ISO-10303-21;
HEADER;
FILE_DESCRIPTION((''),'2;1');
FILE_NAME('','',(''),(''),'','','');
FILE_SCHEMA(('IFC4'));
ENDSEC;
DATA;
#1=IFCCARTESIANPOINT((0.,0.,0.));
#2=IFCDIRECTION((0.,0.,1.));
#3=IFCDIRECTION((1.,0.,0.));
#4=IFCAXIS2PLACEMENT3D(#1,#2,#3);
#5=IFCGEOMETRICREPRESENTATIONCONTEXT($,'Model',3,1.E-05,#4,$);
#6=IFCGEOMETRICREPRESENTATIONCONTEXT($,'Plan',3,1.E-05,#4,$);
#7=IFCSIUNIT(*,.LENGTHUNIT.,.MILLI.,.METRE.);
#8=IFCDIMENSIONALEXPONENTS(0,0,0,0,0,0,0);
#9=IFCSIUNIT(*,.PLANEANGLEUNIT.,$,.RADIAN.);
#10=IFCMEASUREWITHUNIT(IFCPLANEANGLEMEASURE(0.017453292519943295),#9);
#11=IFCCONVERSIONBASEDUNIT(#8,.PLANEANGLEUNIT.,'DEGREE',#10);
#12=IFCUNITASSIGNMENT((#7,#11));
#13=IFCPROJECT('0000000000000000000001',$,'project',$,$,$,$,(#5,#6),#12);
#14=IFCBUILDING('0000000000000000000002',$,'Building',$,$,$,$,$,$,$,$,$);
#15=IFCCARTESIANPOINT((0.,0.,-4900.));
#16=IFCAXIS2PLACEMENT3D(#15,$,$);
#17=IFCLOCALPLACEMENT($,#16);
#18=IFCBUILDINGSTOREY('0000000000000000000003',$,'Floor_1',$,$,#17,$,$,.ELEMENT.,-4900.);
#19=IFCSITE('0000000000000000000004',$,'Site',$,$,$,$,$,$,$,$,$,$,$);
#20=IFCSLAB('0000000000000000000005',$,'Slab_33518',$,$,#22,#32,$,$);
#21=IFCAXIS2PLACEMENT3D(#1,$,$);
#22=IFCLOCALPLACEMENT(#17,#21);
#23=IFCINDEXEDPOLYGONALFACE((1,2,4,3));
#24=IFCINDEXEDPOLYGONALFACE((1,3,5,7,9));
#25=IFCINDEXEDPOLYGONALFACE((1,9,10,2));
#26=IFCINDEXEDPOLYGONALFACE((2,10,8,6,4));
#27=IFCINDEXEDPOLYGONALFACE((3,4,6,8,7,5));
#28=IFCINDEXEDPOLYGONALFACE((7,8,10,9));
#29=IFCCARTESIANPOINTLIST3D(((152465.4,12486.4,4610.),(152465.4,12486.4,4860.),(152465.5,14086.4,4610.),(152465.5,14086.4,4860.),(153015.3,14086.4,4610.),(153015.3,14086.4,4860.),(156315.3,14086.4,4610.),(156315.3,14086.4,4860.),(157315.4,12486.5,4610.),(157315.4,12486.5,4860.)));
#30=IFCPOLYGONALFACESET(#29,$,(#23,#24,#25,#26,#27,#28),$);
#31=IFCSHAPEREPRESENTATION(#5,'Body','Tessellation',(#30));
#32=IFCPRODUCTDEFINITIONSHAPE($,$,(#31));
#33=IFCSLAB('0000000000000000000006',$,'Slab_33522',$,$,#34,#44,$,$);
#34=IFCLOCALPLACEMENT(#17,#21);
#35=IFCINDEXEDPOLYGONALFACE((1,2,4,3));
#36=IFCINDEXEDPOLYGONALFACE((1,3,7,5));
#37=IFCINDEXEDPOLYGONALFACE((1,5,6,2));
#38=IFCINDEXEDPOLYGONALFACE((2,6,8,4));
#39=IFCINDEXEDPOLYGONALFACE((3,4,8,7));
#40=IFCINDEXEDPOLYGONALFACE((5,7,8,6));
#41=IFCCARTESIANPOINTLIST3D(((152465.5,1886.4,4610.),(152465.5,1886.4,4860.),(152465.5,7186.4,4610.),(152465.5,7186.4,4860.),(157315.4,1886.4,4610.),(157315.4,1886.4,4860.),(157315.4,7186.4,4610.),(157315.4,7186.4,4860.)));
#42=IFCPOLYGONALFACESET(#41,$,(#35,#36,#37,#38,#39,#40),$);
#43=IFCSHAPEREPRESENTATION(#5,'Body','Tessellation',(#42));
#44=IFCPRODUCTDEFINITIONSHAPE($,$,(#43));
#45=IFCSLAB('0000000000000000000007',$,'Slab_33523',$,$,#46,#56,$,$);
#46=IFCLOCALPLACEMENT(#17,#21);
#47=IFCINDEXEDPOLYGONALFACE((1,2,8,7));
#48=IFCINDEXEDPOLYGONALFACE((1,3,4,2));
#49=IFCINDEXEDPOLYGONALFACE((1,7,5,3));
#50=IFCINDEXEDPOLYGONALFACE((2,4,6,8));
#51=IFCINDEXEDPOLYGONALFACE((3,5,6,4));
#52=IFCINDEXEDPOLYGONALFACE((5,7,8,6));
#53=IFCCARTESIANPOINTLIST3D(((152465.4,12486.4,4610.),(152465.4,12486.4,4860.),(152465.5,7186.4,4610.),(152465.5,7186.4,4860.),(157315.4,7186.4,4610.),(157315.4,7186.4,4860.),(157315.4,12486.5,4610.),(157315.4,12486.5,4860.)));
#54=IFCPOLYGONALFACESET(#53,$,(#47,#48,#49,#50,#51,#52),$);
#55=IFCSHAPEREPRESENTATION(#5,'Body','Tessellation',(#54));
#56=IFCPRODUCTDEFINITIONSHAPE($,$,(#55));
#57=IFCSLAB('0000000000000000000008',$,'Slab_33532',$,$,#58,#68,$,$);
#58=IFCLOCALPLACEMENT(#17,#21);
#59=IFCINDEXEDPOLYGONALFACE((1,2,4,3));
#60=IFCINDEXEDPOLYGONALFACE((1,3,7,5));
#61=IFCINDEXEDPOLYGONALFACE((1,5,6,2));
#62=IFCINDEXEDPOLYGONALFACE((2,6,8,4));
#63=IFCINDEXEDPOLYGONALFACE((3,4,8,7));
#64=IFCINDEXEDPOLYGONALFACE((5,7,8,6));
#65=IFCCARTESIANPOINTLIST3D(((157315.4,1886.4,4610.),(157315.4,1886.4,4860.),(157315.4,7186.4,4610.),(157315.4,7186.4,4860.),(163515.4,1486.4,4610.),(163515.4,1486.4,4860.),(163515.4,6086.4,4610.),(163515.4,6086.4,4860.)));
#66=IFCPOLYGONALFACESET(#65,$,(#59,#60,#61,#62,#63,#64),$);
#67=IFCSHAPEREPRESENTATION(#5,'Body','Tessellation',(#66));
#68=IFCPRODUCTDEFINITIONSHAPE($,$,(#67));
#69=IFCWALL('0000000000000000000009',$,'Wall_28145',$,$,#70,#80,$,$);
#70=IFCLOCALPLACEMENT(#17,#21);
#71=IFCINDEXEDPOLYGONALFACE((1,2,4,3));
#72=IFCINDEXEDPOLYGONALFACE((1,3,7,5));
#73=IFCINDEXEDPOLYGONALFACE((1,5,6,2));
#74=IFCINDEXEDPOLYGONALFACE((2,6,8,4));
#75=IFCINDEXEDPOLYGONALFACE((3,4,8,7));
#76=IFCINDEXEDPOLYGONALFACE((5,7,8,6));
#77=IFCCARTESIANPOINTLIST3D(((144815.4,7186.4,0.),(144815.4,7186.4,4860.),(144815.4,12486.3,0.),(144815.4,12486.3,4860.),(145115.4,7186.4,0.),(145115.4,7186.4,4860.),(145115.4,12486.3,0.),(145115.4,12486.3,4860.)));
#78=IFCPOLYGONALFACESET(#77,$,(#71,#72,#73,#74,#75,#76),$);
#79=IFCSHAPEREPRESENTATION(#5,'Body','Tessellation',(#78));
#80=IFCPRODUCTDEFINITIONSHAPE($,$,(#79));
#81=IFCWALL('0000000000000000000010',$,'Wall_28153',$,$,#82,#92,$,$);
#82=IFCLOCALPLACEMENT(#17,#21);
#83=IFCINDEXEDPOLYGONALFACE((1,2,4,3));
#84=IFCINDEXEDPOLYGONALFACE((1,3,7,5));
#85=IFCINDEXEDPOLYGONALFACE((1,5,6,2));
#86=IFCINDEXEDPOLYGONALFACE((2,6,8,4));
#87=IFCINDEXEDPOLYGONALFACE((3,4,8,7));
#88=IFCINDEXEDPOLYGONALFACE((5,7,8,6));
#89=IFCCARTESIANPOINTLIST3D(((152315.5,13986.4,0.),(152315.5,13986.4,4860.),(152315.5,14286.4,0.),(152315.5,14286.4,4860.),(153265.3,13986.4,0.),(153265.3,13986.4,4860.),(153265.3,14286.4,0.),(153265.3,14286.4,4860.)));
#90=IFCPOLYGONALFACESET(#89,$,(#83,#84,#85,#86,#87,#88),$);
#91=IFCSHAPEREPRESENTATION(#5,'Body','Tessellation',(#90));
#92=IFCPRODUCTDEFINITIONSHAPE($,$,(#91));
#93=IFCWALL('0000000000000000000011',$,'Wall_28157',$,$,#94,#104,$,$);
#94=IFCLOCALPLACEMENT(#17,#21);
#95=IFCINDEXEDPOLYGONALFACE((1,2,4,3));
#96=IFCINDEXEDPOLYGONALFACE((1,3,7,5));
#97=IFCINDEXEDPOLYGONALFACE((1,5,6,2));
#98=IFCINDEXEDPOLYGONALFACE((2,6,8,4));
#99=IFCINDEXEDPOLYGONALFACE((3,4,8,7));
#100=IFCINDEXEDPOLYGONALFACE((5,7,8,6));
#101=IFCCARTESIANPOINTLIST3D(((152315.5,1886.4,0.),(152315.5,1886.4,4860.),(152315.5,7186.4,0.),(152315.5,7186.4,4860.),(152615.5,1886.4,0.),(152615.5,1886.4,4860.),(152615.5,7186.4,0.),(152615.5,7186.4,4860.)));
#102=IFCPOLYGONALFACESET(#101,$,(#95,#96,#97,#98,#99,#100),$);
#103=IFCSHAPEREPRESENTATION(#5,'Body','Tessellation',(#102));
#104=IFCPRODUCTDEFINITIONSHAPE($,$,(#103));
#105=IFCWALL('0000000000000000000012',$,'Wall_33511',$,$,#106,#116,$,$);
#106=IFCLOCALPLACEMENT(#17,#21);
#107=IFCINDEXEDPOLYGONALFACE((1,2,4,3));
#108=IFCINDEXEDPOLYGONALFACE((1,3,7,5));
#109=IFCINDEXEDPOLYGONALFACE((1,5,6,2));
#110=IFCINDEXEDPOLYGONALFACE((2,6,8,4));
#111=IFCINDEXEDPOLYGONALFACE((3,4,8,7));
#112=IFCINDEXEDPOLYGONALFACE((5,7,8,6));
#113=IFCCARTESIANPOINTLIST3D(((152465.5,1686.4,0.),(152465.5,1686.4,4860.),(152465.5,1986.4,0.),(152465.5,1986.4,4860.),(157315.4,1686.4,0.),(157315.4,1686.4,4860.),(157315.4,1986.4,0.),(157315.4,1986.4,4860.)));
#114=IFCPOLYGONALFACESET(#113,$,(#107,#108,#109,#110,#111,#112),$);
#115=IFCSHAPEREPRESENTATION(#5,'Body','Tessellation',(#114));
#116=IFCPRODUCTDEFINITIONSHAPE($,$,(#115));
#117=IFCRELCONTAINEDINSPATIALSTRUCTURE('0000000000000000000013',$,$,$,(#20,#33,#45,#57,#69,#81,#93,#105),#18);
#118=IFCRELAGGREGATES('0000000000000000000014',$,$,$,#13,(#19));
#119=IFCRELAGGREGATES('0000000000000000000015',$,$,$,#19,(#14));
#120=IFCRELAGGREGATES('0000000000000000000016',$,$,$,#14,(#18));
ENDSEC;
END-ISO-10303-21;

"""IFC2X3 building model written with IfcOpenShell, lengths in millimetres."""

from ifc_helpers import new_model, entity, si_unit, converted_unit, frame, origin_with_axes, origin_2d, place, context, project, spatial, polyline, rectangle, outline, extrude, element, save


model = new_model("IFC2X3")

# Units and contexts
model_context = context("Model", 3, precision=1e-05, world=origin_with_axes())
plan_context = context("Plan", 3, precision=1e-05, world=origin_with_axes())
ifc_project = project(units=[si_unit("LENGTHUNIT", "METRE", prefix="MILLI"), converted_unit("PLANEANGLEUNIT", "DEGREE", entity("IfcPlaneAngleMeasure", 0.017453292519943295), si_unit("PLANEANGLEUNIT", "RADIAN"), dimensions=[0, 0, 0, 0, 0, 0, 0])], contexts=[model_context, plan_context])

# Site, building, storey
site = spatial("IfcSite", under=ifc_project, Name="Site")
building = spatial("IfcBuilding", under=site, Name="Building")
storey_placement = place(None, frame((0.0, 0.0, -4900.0)))
storey = spatial("IfcBuildingStorey", under=building, at=storey_placement, Name="Floor_1", CompositionType="ELEMENT", Elevation=-4900.0)

# Slabs
slab_1_placement = place(storey_placement, frame((153015.3, 14086.4, 4610.0), z_axis=(0.0, 0.0, 1.0), x_axis=(-549.854, 0.0, 0.0)))
element("IfcSlab", 1, at=slab_1_placement, inside=storey, Name="Slab_33518", context=model_context, shape_type="SweptSolid", body=[
    extrude(outline(polyline([(0.0, 0.0), (549.9, 0.0), (549.9, 1600.0), (-4300.1, 1599.9), (-3300.0, 0.0)])), origin_with_axes(), (0.0, 0.0, 1.0), 250.0),
])
slab_2_placement = place(storey_placement, frame((152465.5, 7186.4, 4610.0), z_axis=(0.0, 0.0, 1.0), x_axis=(0.0, -5300.0, 0.0)))
element("IfcSlab", 2, at=slab_2_placement, inside=storey, Name="Slab_33522", context=model_context, shape_type="SweptSolid", body=[
    extrude(outline(polyline([(0.0, 0.0), (5300.0, 0.0), (5300.0, 4849.9), (0.0, 4849.9)])), origin_with_axes(), (0.0, 0.0, 1.0), 250.0),
])
slab_3_placement = place(storey_placement, frame((152465.4, 12486.4, 4610.0), z_axis=(0.0, 0.0, 1.0), x_axis=(0.052, -5300.046, 0.0)))
element("IfcSlab", 3, at=slab_3_placement, inside=storey, Name="Slab_33523", context=model_context, shape_type="SweptSolid", body=[
    extrude(outline(polyline([(0.0, 0.0), (5300.0, 0.0), (5300.1, 4849.9), (0.0, 4850.0)])), origin_with_axes(), (0.0, 0.0, 1.0), 250.0),
])
slab_4_placement = place(storey_placement, frame((157315.4, 7186.4, 4610.0), z_axis=(0.0, 0.0, 1.0), x_axis=(0.0, -5300.012, 0.0)))
element("IfcSlab", 4, at=slab_4_placement, inside=storey, Name="Slab_33532", context=model_context, shape_type="SweptSolid", body=[
    extrude(outline(polyline([(0.0, 0.0), (5300.0, 0.0), (5700.0, 6200.0), (1100.0, 6200.0)])), origin_with_axes(), (0.0, 0.0, 1.0), 250.0),
])

# Walls
wall_1_placement = place(storey_placement, frame((144965.4, 9836.3, 0.0), z_axis=(0.0, 0.0, 1.0), x_axis=(0.0, 5299.937, 0.0)))
element("IfcWall", 5, at=wall_1_placement, inside=storey, Name="Wall_28145", context=model_context, shape_type="SweptSolid", body=[
    extrude(rectangle(XDim=5299.9, YDim=300.0, at=origin_2d()), origin_with_axes(), (0.0, 0.0, 1.0), 4860.0),
])
wall_2_placement = place(storey_placement, frame((152790.4, 14136.4, 0.0), z_axis=(0.0, 0.0, 1.0), x_axis=(949.854055, 0.0, 0.0)))
element("IfcWall", 6, at=wall_2_placement, inside=storey, Name="Wall_28153", context=model_context, shape_type="SweptSolid", body=[
    extrude(rectangle(XDim=949.9, YDim=300.0, at=origin_2d()), origin_with_axes(), (0.0, 0.0, 1.0), 4860.0),
])
wall_3_placement = place(storey_placement, frame((152465.5, 4536.4, 0.0), z_axis=(0.0, 0.0, 1.0), x_axis=(0.0, 5300.0, 0.0)))
element("IfcWall", 7, at=wall_3_placement, inside=storey, Name="Wall_28157", context=model_context, shape_type="SweptSolid", body=[
    extrude(rectangle(XDim=5300.0, YDim=300.0, at=origin_2d()), origin_with_axes(), (0.0, 0.0, 1.0), 4860.0),
])
wall_4_placement = place(storey_placement, frame((154890.4, 1836.4, 0.0), z_axis=(0.0, 0.0, 1.0), x_axis=(4849.920751, 0.0, 0.0)))
element("IfcWall", 8, at=wall_4_placement, inside=storey, Name="Wall_33511", context=model_context, shape_type="SweptSolid", body=[
    extrude(rectangle(XDim=4849.9, YDim=300.0, at=origin_2d()), origin_with_axes(), (0.0, 0.0, 1.0), 4860.0),
])

save(model, "model.ifc")
